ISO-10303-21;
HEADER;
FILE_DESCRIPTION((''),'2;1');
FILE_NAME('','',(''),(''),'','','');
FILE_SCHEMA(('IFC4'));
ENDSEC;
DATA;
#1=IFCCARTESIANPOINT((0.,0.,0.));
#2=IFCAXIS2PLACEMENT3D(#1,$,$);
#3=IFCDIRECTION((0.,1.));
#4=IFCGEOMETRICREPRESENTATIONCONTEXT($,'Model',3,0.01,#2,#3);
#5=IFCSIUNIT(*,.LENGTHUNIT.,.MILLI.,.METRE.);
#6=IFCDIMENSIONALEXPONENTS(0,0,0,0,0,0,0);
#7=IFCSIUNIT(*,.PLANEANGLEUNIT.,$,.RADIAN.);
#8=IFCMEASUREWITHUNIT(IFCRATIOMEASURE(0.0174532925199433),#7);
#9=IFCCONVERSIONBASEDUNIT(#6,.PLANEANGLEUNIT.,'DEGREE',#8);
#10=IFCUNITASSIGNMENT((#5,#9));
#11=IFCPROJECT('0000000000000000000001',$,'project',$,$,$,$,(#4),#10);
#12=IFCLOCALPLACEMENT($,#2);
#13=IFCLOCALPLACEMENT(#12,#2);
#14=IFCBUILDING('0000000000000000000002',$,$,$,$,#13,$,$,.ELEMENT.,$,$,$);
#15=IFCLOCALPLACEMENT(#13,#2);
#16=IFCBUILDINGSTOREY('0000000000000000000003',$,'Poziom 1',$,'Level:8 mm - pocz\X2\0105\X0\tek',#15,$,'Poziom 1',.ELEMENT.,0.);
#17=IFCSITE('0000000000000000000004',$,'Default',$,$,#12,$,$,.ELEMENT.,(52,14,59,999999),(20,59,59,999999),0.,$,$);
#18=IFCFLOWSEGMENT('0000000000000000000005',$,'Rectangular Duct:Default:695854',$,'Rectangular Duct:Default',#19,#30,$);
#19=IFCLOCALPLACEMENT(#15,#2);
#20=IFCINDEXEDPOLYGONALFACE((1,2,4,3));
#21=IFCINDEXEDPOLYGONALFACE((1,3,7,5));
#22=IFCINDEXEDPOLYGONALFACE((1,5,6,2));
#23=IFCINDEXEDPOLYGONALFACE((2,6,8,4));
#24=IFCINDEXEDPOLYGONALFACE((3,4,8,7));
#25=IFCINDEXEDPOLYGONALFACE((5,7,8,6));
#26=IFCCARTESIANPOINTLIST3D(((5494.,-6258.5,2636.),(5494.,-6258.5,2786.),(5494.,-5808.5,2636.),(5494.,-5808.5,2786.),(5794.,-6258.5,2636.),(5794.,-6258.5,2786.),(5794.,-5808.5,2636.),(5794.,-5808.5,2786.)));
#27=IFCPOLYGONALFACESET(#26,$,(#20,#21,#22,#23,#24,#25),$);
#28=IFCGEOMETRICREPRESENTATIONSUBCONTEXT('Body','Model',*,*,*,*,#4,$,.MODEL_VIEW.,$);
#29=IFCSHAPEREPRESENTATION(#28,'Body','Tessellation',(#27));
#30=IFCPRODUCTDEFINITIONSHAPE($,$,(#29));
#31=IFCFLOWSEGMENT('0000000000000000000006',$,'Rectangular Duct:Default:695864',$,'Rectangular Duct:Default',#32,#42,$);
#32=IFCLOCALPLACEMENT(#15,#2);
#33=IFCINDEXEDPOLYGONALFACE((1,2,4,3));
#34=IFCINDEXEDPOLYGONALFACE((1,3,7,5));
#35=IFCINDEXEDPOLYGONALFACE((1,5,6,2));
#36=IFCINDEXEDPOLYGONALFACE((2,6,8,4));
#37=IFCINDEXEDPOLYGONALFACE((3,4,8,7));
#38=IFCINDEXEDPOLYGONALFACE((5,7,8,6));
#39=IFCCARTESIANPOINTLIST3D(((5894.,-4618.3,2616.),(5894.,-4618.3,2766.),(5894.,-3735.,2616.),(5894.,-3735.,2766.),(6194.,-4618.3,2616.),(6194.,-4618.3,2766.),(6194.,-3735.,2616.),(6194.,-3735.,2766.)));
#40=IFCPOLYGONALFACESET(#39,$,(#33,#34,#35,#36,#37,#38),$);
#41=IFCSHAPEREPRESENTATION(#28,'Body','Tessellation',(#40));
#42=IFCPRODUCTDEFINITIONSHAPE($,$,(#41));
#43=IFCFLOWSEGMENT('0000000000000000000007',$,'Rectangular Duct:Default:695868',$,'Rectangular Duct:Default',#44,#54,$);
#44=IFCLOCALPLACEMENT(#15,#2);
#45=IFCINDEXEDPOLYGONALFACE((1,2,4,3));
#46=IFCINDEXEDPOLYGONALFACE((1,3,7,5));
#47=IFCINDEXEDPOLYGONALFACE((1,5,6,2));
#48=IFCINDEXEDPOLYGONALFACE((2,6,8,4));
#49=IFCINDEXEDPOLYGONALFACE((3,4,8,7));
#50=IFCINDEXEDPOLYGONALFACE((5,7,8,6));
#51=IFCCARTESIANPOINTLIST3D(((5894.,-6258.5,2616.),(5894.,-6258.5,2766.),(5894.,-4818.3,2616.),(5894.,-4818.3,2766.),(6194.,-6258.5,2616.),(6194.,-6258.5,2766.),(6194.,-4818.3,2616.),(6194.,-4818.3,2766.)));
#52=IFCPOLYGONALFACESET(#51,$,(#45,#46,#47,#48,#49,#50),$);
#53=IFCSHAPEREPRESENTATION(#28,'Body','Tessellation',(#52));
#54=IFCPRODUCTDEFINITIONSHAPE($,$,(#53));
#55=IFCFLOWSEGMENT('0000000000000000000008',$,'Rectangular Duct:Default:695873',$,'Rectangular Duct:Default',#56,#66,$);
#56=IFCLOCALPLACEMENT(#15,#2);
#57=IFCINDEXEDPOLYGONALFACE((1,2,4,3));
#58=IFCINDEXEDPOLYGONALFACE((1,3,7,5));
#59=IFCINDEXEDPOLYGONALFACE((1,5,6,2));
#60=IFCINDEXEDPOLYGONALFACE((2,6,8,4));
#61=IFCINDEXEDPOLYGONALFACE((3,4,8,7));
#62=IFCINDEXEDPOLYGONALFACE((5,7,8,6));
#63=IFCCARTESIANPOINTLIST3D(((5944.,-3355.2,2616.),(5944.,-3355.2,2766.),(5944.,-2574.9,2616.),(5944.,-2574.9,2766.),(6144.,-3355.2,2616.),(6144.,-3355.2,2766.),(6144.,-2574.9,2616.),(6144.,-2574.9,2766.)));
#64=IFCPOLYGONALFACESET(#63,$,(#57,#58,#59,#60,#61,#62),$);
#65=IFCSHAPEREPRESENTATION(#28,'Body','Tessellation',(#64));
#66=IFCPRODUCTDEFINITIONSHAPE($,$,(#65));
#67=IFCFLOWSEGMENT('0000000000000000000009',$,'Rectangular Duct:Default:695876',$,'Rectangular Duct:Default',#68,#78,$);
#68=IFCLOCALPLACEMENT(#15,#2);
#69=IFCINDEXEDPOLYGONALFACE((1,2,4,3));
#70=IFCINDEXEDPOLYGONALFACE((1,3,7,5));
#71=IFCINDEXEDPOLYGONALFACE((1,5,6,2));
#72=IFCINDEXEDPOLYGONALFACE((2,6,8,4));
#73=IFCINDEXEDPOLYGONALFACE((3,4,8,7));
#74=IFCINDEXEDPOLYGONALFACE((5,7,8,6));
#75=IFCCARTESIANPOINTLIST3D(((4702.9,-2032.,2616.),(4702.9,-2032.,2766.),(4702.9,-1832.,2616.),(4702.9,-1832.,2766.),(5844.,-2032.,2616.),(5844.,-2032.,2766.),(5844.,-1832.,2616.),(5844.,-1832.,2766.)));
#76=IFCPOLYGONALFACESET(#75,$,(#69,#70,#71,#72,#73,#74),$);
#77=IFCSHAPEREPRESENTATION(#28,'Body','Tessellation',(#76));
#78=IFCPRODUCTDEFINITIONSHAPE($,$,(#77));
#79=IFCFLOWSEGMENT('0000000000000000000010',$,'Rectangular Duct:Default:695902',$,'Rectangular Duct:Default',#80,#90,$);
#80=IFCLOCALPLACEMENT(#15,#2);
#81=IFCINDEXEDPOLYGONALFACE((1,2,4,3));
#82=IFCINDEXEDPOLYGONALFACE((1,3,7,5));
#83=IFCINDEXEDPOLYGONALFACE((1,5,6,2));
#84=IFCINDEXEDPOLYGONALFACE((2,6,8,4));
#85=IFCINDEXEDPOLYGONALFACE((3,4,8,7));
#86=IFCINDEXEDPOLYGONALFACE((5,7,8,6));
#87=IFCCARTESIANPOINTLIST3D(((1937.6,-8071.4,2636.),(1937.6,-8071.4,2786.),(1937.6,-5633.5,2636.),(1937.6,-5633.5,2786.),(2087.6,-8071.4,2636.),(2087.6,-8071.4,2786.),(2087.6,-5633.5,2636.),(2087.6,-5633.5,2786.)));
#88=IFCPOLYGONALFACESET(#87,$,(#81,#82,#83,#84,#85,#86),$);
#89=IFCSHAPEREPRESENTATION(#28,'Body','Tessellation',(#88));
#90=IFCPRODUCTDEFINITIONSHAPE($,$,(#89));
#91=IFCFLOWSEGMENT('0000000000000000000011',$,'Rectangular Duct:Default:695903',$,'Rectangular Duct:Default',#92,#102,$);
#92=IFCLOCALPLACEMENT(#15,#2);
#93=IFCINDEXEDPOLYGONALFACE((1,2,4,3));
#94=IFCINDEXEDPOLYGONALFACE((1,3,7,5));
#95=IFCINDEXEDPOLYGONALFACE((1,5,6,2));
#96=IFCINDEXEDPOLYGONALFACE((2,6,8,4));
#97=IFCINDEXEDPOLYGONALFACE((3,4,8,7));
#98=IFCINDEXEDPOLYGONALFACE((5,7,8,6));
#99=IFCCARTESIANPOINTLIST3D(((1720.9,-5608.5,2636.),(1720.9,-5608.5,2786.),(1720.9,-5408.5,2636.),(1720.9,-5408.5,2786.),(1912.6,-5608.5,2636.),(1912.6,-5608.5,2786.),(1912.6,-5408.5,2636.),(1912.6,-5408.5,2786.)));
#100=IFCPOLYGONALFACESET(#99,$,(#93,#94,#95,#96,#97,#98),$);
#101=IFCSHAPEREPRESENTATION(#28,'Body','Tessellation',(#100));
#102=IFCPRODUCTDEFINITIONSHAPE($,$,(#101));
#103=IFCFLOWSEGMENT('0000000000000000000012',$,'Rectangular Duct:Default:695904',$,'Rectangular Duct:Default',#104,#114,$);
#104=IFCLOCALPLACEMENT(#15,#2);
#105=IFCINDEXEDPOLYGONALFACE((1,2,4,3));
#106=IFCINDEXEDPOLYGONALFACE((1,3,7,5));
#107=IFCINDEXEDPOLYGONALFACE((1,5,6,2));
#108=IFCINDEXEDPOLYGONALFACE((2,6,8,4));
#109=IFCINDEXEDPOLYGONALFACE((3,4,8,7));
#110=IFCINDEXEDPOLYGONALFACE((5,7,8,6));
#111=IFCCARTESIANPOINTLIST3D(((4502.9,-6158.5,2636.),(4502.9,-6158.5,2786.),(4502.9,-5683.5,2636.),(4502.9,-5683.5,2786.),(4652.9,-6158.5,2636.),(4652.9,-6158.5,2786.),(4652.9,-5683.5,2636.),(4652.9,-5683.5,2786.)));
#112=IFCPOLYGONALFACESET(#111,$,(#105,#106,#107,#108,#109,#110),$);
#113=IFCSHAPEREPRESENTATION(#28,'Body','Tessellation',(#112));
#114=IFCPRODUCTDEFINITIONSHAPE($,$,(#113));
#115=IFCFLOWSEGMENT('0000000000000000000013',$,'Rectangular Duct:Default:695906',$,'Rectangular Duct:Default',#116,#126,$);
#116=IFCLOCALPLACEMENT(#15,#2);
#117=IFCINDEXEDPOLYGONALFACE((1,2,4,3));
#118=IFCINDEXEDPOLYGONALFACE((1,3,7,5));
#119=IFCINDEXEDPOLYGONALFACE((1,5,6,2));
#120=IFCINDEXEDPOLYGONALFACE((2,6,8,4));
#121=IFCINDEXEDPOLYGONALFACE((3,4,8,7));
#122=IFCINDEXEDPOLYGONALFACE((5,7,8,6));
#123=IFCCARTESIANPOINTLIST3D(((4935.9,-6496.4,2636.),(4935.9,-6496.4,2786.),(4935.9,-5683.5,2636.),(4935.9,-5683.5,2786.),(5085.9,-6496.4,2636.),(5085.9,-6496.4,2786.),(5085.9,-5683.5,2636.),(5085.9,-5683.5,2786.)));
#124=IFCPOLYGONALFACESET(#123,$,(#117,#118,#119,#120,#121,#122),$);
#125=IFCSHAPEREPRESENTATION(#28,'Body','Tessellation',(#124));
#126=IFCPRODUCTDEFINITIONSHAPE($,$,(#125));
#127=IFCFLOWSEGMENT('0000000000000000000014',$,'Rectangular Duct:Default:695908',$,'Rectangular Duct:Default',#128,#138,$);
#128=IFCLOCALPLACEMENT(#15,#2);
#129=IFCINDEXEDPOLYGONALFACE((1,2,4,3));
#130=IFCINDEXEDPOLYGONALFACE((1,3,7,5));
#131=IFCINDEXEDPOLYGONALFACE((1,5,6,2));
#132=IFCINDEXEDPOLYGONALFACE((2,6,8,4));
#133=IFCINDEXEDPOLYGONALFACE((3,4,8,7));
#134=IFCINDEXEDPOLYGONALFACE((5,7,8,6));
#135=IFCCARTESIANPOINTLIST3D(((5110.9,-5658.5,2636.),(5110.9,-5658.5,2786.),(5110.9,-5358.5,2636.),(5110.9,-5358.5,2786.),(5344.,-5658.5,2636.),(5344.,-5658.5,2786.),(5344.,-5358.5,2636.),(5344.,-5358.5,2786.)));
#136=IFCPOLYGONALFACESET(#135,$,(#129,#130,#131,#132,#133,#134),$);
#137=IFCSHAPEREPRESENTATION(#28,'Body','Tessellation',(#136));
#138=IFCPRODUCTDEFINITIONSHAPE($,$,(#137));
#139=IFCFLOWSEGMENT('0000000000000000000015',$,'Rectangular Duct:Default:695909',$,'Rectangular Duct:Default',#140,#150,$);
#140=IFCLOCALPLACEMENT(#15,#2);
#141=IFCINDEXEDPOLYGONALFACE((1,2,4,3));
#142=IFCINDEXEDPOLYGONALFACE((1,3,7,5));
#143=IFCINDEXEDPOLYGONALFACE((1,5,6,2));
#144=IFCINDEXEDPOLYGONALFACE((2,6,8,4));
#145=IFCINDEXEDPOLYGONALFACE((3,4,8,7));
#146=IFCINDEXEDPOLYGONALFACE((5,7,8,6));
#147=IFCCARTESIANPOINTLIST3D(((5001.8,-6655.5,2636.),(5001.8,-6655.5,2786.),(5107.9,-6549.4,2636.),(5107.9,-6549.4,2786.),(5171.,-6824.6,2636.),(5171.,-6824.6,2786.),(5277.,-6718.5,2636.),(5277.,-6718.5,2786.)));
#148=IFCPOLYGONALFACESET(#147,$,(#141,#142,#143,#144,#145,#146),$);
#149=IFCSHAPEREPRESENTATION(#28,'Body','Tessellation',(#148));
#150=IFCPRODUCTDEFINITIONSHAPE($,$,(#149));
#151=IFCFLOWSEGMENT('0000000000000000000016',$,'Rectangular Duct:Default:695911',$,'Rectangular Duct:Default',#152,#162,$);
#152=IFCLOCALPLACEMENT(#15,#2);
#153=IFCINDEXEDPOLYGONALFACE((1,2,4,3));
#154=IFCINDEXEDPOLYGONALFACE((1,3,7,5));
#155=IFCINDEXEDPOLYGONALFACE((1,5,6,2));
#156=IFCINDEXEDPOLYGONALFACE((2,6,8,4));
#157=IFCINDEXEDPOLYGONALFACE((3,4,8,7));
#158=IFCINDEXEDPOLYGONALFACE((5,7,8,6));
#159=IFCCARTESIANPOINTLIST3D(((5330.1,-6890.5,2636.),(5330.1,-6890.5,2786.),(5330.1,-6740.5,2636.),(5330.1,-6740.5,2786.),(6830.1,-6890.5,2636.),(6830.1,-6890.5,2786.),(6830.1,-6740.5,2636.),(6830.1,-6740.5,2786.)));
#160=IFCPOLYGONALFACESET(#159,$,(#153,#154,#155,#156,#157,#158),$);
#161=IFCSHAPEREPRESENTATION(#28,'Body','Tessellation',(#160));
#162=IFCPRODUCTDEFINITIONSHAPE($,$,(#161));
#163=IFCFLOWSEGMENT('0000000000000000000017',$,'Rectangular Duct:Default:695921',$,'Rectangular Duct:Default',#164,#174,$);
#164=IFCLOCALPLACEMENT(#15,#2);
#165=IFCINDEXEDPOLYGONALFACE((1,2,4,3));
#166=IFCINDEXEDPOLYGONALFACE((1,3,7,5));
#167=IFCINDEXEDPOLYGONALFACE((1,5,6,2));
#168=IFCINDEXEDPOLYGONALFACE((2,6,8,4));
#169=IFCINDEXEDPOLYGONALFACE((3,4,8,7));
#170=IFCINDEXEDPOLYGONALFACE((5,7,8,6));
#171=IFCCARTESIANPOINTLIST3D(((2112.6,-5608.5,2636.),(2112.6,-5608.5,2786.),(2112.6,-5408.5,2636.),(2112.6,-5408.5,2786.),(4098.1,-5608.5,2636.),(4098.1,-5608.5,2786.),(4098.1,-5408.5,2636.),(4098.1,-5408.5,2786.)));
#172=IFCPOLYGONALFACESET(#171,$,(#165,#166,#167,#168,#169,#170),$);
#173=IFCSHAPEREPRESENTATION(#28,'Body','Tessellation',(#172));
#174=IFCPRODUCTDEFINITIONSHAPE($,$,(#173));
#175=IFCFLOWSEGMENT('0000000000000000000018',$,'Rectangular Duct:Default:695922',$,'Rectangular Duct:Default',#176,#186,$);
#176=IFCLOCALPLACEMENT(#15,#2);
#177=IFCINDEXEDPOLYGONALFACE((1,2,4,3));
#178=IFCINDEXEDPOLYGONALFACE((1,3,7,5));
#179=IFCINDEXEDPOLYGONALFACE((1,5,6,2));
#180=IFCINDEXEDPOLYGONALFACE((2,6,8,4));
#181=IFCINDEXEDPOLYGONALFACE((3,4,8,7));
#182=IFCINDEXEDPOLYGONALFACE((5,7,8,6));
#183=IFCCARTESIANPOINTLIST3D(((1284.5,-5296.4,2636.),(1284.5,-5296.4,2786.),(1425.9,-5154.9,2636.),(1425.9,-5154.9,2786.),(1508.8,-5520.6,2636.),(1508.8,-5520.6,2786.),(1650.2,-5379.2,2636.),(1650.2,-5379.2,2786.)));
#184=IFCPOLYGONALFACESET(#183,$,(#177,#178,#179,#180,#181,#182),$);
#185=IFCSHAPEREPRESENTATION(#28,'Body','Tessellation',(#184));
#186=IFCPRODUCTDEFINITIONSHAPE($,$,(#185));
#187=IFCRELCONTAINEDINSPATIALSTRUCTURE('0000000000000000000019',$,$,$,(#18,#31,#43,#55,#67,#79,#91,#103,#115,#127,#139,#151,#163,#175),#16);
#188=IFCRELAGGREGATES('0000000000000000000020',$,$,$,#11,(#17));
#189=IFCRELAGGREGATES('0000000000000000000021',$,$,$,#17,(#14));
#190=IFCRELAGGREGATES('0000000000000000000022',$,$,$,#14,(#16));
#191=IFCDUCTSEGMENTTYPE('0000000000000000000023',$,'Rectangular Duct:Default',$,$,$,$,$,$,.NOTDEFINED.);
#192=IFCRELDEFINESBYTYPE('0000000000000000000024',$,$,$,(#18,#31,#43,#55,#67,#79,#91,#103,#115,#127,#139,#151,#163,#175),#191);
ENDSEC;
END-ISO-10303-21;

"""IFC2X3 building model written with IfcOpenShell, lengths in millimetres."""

from ifc_helpers import new_model, entity, si_unit, converted_unit, direction, frame, frame_2d, origin, origin_2d_with_axis, place, context, subcontext, project, spatial, rectangle, extrude, type_object, element, save


model = new_model("IFC2X3")

# Units and contexts
model_context = context("Model", 3, precision=0.01, world=origin(), true_north=direction((0.0, 1.0)))
body_context = subcontext(model_context, "Body", "Model", "MODEL_VIEW")
ifc_project = project(units=[si_unit("LENGTHUNIT", "METRE", prefix="MILLI"), converted_unit("PLANEANGLEUNIT", "DEGREE", entity("IfcRatioMeasure", 0.0174532925199433), si_unit("PLANEANGLEUNIT", "RADIAN"), dimensions=[0, 0, 0, 0, 0, 0, 0])], contexts=[model_context])

# Site, building, storey
site_placement = place(None, origin())
site = spatial("IfcSite", under=ifc_project, at=site_placement, Name="Default", CompositionType="ELEMENT", RefLatitude=(52, 14, 59, 999999), RefLongitude=(20, 59, 59, 999999), RefElevation=0.0)
building_placement = place(site_placement, origin())
building = spatial("IfcBuilding", under=site, at=building_placement, CompositionType="ELEMENT")
storey_placement = place(building_placement, origin())
storey = spatial("IfcBuildingStorey", under=building, at=storey_placement, Name="Poziom 1", ObjectType="Level:8 mm - początek", LongName="Poziom 1", CompositionType="ELEMENT", Elevation=0.0)

# Flow segments
duct_segment_type_1 = type_object("IfcDuctSegmentType", Name="Rectangular Duct:Default", PredefinedType="NOTDEFINED")
flow_segment_1_placement = place(storey_placement, origin())
element("IfcFlowSegment", 1, at=flow_segment_1_placement, inside=storey, type_object=duct_segment_type_1, Name="Rectangular Duct:Default:695854", ObjectType="Rectangular Duct:Default", context=body_context, shape_type="SweptSolid", body=[
    extrude(rectangle(XDim=450.0, YDim=300.0, at=origin_2d_with_axis()), frame((5644.0, -6033.5, 2636.0), z_axis=(0.0, 0.0, 1.0), x_axis=(0.0, 1.0, 0.0)), (0.0, 0.0, 1.0), 150.0),
])
flow_segment_2_placement = place(storey_placement, origin())
element("IfcFlowSegment", 2, at=flow_segment_2_placement, inside=storey, type_object=duct_segment_type_1, Name="Rectangular Duct:Default:695864", ObjectType="Rectangular Duct:Default", context=body_context, shape_type="SweptSolid", body=[
    extrude(rectangle(XDim=883.3, YDim=300.0, at=frame_2d((0.0, 0.0), x_axis=(1.0, 0.0))), frame((6044.0, -4176.7, 2616.0), z_axis=(0.0, 0.0, 1.0), x_axis=(0.0, 1.0, 0.0)), (0.0, 0.0, 1.0), 150.0),
])
flow_segment_3_placement = place(storey_placement, origin())
element("IfcFlowSegment", 3, at=flow_segment_3_placement, inside=storey, type_object=duct_segment_type_1, Name="Rectangular Duct:Default:695868", ObjectType="Rectangular Duct:Default", context=body_context, shape_type="SweptSolid", body=[
    extrude(rectangle(XDim=1440.2, YDim=300.0, at=frame_2d((0.0, 0.0), x_axis=(1.0, 0.0))), frame((6044.0, -5538.4, 2616.0), z_axis=(0.0, 0.0, 1.0), x_axis=(0.0, 1.0, 0.0)), (0.0, 0.0, 1.0), 150.0),
])
flow_segment_4_placement = place(storey_placement, origin())
element("IfcFlowSegment", 4, at=flow_segment_4_placement, inside=storey, type_object=duct_segment_type_1, Name="Rectangular Duct:Default:695873", ObjectType="Rectangular Duct:Default", context=body_context, shape_type="SweptSolid", body=[
    extrude(rectangle(XDim=780.4, YDim=200.0, at=frame_2d((0.0, 0.0), x_axis=(1.0, 0.0))), frame((6044.0, -2965.0, 2616.0), z_axis=(0.0, 0.0, 1.0), x_axis=(0.0, 1.0, 0.0)), (0.0, 0.0, 1.0), 150.0),
])
flow_segment_5_placement = place(storey_placement, origin())
element("IfcFlowSegment", 5, at=flow_segment_5_placement, inside=storey, type_object=duct_segment_type_1, Name="Rectangular Duct:Default:695876", ObjectType="Rectangular Duct:Default", context=body_context, shape_type="SweptSolid", body=[
    extrude(rectangle(XDim=1141.1, YDim=200.0, at=frame_2d((0.0, 0.0), x_axis=(1.0, 0.0))), frame((5273.4, -1932.0, 2616.0), z_axis=(0.0, 0.0, 1.0), x_axis=(-1.0, 0.0, 0.0)), (0.0, 0.0, 1.0), 150.0),
])
flow_segment_6_placement = place(storey_placement, origin())
element("IfcFlowSegment", 6, at=flow_segment_6_placement, inside=storey, type_object=duct_segment_type_1, Name="Rectangular Duct:Default:695902", ObjectType="Rectangular Duct:Default", context=body_context, shape_type="SweptSolid", body=[
    extrude(rectangle(XDim=2437.9, YDim=150.0, at=frame_2d((0.0, 0.0), x_axis=(1.0, 0.0))), frame((2012.6, -6852.4, 2636.0), z_axis=(0.0, 0.0, 1.0), x_axis=(0.0, -1.0, 0.0)), (0.0, 0.0, 1.0), 150.0),
])
flow_segment_7_placement = place(storey_placement, origin())
element("IfcFlowSegment", 7, at=flow_segment_7_placement, inside=storey, type_object=duct_segment_type_1, Name="Rectangular Duct:Default:695903", ObjectType="Rectangular Duct:Default", context=body_context, shape_type="SweptSolid", body=[
    extrude(rectangle(XDim=191.7, YDim=200.0, at=frame_2d((0.0, 0.0), x_axis=(1.0, 0.0))), frame((1816.7, -5508.5, 2636.0), z_axis=(0.0, 0.0, 1.0), x_axis=(-1.0, 0.0, 0.0)), (0.0, 0.0, 1.0), 150.0),
])
flow_segment_8_placement = place(storey_placement, origin())
element("IfcFlowSegment", 8, at=flow_segment_8_placement, inside=storey, type_object=duct_segment_type_1, Name="Rectangular Duct:Default:695904", ObjectType="Rectangular Duct:Default", context=body_context, shape_type="SweptSolid", body=[
    extrude(rectangle(XDim=475.0, YDim=150.0, at=frame_2d((0.0, 0.0), x_axis=(1.0, 0.0))), frame((4577.9, -5921.0, 2636.0), z_axis=(0.0, 0.0, 1.0), x_axis=(0.0, 1.0, 0.0)), (0.0, 0.0, 1.0), 150.0),
])
flow_segment_9_placement = place(storey_placement, origin())
element("IfcFlowSegment", 9, at=flow_segment_9_placement, inside=storey, type_object=duct_segment_type_1, Name="Rectangular Duct:Default:695906", ObjectType="Rectangular Duct:Default", context=body_context, shape_type="SweptSolid", body=[
    extrude(rectangle(XDim=812.9, YDim=150.0, at=origin_2d_with_axis()), frame((5010.9, -6089.9, 2636.0), z_axis=(0.0, 0.0, 1.0), x_axis=(0.0, -1.0, 0.0)), (0.0, 0.0, 1.0), 150.0),
])
flow_segment_10_placement = place(storey_placement, origin())
element("IfcFlowSegment", 10, at=flow_segment_10_placement, inside=storey, type_object=duct_segment_type_1, Name="Rectangular Duct:Default:695908", ObjectType="Rectangular Duct:Default", context=body_context, shape_type="SweptSolid", body=[
    extrude(rectangle(XDim=233.1, YDim=300.0, at=frame_2d((0.0, 0.0), x_axis=(1.0, 0.0))), frame((5227.5, -5508.5, 2636.0), z_axis=(0.0, 0.0, 1.0), x_axis=(-1.0, 0.0, 0.0)), (0.0, 0.0, 1.0), 150.0),
])
flow_segment_11_placement = place(storey_placement, origin())
element("IfcFlowSegment", 11, at=flow_segment_11_placement, inside=storey, type_object=duct_segment_type_1, Name="Rectangular Duct:Default:695909", ObjectType="Rectangular Duct:Default", context=body_context, shape_type="SweptSolid", body=[
    extrude(rectangle(XDim=239.2, YDim=150.0, at=origin_2d_with_axis()), frame((5139.4, -6687.0, 2636.0), z_axis=(0.0, 0.0, 1.0), x_axis=(0.707107, -0.707107, 0.0)), (0.0, 0.0, 1.0), 150.0),
])
flow_segment_12_placement = place(storey_placement, origin())
element("IfcFlowSegment", 12, at=flow_segment_12_placement, inside=storey, type_object=duct_segment_type_1, Name="Rectangular Duct:Default:695911", ObjectType="Rectangular Duct:Default", context=body_context, shape_type="SweptSolid", body=[
    extrude(rectangle(XDim=1500.0, YDim=150.0, at=frame_2d((0.0, 0.0), x_axis=(1.0, 0.0))), frame((6080.1, -6815.5, 2636.0)), (0.0, 0.0, 1.0), 150.0),
])
flow_segment_13_placement = place(storey_placement, origin())
element("IfcFlowSegment", 13, at=flow_segment_13_placement, inside=storey, type_object=duct_segment_type_1, Name="Rectangular Duct:Default:695921", ObjectType="Rectangular Duct:Default", context=body_context, shape_type="SweptSolid", body=[
    extrude(rectangle(XDim=1985.5, YDim=200.0, at=origin_2d_with_axis()), frame((3105.3, -5508.5, 2636.0)), (0.0, 0.0, 1.0), 150.0),
])
flow_segment_14_placement = place(storey_placement, origin())
element("IfcFlowSegment", 14, at=flow_segment_14_placement, inside=storey, type_object=duct_segment_type_1, Name="Rectangular Duct:Default:695922", ObjectType="Rectangular Duct:Default", context=body_context, shape_type="SweptSolid", body=[
    extrude(rectangle(XDim=317.2, YDim=200.0, at=frame_2d((0.0, 0.0), x_axis=(1.0, 0.0))), frame((1467.4, -5337.8, 2636.0), z_axis=(0.0, 0.0, 1.0), x_axis=(-0.707107, 0.707107, 0.0)), (0.0, 0.0, 1.0), 150.0),
])

save(model, "model.ifc")
